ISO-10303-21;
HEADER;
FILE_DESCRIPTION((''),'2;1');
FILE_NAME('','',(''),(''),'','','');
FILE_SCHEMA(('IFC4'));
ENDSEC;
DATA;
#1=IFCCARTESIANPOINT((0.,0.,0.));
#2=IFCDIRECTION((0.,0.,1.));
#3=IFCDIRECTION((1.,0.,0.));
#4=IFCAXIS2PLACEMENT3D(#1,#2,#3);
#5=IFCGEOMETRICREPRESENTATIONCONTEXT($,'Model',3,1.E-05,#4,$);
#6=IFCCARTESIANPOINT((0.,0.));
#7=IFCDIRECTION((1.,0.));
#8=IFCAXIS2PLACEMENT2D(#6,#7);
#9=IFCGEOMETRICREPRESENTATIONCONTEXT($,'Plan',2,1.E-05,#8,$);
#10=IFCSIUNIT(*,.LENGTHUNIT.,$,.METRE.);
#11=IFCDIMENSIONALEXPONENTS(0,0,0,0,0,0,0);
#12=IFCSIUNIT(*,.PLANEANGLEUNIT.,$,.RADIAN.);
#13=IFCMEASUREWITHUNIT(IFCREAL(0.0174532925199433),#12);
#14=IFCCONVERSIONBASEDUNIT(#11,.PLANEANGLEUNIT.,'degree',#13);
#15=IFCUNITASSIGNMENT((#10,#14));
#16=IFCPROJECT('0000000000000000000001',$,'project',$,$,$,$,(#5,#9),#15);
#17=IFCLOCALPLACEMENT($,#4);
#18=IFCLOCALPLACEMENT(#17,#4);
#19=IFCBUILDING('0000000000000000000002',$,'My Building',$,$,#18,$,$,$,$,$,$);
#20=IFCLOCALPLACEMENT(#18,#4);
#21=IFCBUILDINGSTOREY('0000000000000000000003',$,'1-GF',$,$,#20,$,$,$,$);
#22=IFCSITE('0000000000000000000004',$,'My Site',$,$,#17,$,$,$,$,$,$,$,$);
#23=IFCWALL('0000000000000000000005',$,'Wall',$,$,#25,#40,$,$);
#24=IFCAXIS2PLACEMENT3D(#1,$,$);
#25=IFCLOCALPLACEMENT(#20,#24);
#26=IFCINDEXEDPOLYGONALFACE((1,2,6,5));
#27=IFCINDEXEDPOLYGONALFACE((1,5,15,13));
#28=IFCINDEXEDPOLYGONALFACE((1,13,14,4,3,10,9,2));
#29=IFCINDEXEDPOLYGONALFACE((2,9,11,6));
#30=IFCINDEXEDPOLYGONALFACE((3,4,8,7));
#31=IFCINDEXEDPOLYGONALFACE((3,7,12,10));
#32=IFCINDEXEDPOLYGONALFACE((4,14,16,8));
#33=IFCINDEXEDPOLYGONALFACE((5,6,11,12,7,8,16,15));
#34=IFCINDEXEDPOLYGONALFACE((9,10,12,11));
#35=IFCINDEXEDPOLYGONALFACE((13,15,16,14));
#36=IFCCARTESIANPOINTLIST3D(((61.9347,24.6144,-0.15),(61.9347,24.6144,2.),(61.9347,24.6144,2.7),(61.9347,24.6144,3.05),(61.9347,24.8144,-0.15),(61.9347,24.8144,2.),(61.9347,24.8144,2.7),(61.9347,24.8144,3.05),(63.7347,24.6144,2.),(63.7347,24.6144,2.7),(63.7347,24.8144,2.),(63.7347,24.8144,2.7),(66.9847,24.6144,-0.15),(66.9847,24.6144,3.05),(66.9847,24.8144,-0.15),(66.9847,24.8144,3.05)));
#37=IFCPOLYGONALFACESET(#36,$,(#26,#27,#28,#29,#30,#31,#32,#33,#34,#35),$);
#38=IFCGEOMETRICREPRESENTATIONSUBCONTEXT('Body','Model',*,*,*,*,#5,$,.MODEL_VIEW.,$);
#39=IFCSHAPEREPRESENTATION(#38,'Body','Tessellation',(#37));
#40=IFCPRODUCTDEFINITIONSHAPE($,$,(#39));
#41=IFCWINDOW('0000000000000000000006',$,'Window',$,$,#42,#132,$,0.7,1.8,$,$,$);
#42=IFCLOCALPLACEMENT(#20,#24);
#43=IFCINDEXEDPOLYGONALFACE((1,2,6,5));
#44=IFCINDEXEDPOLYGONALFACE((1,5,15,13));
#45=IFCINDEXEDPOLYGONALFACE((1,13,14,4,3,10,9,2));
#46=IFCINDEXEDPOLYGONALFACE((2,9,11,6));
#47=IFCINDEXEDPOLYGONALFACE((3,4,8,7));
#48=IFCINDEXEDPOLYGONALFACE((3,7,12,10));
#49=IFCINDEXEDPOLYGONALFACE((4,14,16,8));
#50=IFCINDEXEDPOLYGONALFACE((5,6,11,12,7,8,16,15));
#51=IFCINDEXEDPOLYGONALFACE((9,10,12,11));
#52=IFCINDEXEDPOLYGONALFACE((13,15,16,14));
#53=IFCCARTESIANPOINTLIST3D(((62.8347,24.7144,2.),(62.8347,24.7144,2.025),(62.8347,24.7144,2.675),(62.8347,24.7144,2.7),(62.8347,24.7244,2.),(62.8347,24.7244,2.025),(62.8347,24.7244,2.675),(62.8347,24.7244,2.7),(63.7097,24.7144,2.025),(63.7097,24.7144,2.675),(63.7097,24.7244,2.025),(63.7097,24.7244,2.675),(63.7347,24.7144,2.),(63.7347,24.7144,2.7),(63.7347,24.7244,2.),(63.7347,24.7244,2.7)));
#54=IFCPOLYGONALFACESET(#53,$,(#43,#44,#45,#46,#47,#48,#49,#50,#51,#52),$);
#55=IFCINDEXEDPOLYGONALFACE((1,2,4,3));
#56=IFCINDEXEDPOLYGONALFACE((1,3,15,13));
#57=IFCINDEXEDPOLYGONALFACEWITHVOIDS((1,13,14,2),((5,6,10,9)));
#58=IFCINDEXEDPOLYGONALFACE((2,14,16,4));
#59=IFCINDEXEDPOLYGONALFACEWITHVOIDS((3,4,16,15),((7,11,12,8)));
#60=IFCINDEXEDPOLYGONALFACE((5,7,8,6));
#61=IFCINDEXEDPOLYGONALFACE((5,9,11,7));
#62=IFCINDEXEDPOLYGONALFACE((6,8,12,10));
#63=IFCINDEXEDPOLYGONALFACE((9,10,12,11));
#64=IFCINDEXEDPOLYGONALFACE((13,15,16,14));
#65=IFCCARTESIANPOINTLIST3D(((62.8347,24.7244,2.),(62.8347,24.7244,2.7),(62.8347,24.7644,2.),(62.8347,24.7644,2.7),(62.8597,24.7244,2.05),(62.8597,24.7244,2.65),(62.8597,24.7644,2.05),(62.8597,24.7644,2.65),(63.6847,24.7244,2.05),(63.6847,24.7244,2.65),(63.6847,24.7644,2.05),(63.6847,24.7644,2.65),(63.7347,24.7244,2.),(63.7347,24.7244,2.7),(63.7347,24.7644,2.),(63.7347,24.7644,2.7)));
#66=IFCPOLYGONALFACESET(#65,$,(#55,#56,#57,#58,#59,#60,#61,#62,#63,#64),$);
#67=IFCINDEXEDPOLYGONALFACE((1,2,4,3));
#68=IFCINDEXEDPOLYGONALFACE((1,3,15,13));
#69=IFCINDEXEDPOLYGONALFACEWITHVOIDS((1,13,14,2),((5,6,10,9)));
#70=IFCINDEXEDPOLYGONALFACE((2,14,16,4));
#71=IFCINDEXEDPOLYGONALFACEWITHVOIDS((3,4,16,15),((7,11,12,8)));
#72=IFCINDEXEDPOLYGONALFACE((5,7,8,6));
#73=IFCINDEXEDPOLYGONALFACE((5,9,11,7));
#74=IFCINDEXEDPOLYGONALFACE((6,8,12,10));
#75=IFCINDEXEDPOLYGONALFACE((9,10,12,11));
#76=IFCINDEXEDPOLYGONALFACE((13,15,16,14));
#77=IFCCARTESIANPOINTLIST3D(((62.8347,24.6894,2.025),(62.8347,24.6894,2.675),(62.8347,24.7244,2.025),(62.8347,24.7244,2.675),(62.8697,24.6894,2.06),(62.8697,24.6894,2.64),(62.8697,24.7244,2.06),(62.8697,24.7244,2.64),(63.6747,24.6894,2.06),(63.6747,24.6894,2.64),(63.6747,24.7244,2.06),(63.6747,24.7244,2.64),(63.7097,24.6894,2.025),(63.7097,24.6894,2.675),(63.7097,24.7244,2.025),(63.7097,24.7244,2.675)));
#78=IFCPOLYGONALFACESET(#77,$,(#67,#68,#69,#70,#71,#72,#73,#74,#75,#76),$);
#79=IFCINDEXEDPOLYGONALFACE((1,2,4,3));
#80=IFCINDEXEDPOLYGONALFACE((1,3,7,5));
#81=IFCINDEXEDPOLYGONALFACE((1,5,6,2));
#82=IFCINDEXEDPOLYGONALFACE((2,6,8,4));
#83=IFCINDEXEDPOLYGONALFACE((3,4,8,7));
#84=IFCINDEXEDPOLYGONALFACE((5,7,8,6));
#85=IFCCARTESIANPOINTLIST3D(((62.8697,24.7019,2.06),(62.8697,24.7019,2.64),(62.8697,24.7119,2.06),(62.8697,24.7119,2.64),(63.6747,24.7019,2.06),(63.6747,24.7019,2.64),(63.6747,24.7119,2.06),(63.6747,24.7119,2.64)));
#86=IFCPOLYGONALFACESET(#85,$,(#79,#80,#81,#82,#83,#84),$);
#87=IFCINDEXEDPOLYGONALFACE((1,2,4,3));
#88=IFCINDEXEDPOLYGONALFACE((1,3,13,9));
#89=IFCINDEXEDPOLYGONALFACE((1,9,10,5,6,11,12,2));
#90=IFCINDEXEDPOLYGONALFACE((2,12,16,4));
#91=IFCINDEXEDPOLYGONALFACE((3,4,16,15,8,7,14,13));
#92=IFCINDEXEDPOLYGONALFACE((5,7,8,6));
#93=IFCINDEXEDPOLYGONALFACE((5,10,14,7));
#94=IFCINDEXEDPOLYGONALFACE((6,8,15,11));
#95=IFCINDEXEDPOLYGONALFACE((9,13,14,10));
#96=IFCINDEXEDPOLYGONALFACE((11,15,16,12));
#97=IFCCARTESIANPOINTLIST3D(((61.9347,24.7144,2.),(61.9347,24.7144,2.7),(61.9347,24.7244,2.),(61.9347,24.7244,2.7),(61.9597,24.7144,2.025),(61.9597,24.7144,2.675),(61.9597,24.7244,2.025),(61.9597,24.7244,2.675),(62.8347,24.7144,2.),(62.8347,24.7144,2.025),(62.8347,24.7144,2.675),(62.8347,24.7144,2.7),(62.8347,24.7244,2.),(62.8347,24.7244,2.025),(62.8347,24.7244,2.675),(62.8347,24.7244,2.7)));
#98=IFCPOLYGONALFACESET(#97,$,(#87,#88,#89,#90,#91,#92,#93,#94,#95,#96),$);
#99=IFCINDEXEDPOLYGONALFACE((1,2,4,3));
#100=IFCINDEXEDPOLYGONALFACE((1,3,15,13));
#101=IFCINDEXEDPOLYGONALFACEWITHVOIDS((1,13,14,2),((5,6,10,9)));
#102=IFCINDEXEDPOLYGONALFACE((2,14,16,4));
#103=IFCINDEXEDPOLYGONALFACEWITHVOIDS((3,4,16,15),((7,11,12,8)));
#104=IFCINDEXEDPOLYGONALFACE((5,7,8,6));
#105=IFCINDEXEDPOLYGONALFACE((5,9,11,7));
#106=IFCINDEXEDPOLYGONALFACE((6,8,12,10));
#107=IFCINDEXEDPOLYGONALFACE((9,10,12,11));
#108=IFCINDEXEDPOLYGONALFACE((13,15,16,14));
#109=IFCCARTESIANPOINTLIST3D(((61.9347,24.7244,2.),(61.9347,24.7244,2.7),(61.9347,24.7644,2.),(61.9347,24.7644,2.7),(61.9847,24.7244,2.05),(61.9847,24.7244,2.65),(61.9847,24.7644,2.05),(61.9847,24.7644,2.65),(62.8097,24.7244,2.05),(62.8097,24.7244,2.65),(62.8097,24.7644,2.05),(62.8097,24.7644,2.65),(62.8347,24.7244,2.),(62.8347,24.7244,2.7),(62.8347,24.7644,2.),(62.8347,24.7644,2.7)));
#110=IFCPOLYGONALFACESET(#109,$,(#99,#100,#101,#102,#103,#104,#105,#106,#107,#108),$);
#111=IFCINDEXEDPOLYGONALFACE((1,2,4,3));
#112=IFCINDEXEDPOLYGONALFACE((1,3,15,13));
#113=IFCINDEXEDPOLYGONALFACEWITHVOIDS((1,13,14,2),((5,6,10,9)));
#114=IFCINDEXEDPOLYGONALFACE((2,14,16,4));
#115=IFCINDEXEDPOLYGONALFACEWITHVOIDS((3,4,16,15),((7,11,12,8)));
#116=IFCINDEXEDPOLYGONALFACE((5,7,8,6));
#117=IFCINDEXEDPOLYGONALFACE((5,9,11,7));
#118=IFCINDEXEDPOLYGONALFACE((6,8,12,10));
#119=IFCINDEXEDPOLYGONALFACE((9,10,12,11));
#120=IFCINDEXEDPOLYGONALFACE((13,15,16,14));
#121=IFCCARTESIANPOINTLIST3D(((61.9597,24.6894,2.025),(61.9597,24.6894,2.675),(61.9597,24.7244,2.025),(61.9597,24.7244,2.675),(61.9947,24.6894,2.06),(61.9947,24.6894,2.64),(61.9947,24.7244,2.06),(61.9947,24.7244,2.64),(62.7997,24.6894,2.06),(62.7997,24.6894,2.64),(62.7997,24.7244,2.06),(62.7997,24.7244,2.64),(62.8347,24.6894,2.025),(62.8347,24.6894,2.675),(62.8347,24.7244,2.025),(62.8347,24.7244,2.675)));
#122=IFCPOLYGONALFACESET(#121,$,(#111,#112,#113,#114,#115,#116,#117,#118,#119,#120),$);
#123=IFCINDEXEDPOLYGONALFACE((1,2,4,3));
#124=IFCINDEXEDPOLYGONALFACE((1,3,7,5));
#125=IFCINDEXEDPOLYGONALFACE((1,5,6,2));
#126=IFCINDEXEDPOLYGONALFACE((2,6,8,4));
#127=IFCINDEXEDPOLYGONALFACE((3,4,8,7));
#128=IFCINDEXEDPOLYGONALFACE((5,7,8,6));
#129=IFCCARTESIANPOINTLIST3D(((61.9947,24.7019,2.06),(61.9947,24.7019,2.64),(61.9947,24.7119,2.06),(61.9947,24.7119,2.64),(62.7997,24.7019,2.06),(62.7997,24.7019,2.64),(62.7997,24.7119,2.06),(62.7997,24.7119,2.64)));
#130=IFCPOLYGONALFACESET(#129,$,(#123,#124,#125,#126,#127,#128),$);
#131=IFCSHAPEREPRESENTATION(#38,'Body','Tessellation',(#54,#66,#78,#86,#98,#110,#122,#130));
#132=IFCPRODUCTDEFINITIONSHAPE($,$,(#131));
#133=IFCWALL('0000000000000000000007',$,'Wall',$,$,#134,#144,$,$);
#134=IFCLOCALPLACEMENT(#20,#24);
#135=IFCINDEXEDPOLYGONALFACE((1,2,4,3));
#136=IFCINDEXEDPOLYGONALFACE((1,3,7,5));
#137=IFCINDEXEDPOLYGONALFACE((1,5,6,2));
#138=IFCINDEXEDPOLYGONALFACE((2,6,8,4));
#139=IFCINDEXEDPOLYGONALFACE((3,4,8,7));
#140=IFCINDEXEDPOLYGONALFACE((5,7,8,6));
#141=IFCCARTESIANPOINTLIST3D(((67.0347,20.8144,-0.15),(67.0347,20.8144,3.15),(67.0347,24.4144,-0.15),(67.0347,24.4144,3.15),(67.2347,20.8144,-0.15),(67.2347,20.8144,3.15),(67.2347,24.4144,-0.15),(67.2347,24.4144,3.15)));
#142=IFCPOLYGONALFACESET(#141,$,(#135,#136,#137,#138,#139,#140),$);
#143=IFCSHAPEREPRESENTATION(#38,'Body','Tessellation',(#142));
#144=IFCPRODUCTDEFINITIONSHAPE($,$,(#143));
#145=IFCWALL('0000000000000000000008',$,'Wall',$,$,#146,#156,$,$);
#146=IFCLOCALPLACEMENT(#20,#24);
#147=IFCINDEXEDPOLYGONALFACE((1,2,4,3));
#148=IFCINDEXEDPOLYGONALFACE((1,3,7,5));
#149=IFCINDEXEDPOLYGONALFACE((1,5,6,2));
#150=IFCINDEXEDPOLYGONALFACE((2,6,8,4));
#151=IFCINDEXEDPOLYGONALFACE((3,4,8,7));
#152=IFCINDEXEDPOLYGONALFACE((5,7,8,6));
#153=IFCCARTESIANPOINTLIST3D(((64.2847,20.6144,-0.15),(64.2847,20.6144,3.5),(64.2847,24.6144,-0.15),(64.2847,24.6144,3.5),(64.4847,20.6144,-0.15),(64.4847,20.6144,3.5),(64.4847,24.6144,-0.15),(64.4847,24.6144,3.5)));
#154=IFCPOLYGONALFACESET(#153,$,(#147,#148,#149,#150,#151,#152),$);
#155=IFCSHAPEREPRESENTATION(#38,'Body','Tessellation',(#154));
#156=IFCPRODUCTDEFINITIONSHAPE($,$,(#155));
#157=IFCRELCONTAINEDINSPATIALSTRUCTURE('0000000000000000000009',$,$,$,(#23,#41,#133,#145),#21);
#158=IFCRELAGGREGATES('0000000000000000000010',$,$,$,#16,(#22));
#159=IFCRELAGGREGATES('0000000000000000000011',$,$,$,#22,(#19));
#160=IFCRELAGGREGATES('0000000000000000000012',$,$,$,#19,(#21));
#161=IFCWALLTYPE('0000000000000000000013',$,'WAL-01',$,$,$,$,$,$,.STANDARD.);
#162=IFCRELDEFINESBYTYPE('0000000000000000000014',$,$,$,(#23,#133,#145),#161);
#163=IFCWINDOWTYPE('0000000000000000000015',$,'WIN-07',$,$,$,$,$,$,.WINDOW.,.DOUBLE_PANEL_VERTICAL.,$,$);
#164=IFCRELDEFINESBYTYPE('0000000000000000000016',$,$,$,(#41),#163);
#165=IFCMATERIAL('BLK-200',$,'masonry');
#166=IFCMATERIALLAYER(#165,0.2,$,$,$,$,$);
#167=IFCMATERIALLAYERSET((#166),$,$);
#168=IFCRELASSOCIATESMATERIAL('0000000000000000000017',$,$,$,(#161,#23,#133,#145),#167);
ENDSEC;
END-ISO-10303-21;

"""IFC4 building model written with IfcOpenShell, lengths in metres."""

from ifc_helpers import new_model, entity, si_unit, converted_unit, frame, origin_with_axes, origin_2d_with_axis, place, context, subcontext, project, spatial, line, indexed_curve, outline, extrude, shape, source, transform, mapped, material, layer, layer_set, layer_usage, type_object, type_shapes, element, fill, save


model = new_model("IFC4")

# Units and contexts
model_context = context("Model", 3, precision=1e-05, world=origin_with_axes())
plan_context = context("Plan", 2, precision=1e-05, world=origin_2d_with_axis())
body_context_1 = subcontext(model_context, "Body", "Model", "MODEL_VIEW")
body_context_2 = subcontext(plan_context, "Body", "Plan", "PLAN_VIEW")
ifc_project = project(units=[si_unit("LENGTHUNIT", "METRE"), converted_unit("PLANEANGLEUNIT", "degree", entity("IfcReal", 0.0174532925199433), si_unit("PLANEANGLEUNIT", "RADIAN"), dimensions=[0, 0, 0, 0, 0, 0, 0])], contexts=[model_context, plan_context])

# Site, building, storey
site_placement = place(None, origin_with_axes())
site = spatial("IfcSite", under=ifc_project, at=site_placement, Name="My Site")
building_placement = place(site_placement, origin_with_axes())
building = spatial("IfcBuilding", under=site, at=building_placement, Name="My Building")
storey_placement = place(building_placement, origin_with_axes())
storey = spatial("IfcBuildingStorey", under=building, at=storey_placement, Name="1-GF")

# Shared definitions
ifc_material_1 = material(Name="BLK-200", Category="masonry")
ifc_layer_1 = layer(ifc_material_1, 0.2)
ifc_layer_set_1 = layer_set([ifc_layer_1])
wall_type_1 = type_object("IfcWallType", Name="WAL-01", PredefinedType="STANDARD", material=ifc_layer_set_1)
shared_shape_1 = source(origin_with_axes(), body_context_1, "Body", "SweptSolid", [
    extrude(outline(indexed_curve([(0.0, 0.0), (1.8, 0.0), (1.8, 0.7), (0.0, 0.7)], segments=[line(1, 2, 3, 4, 1)])), frame((0.0, -0.1, 0.0), z_axis=(0.0, -1.0, 0.0), x_axis=(1.0, 0.0, 0.0)), (0.0, 0.0, -1.0), 0.4),
])
window_type_1 = type_object("IfcWindowType", Name="WIN-07", PartitioningType="DOUBLE_PANEL_VERTICAL", PredefinedType="WINDOW")
shared_shape_2 = source(origin_with_axes(), body_context_1, "Body", "SweptSolid", [
    extrude(outline(indexed_curve([(0.9, 0.0), (0.0, 0.0), (0.0, 0.7), (0.9, 0.7), (0.9, 0.675), (0.025, 0.675), (0.025, 0.025), (0.9, 0.025)], segments=[line(1, 2, 3, 4, 5, 6, 7, 8, 1)])), frame((0.0, 0.09, 0.0), z_axis=(0.0, -1.0, 0.0), x_axis=(1.0, 0.0, 0.0)), (0.0, 0.0, -1.0), 0.01),
    extrude(outline(indexed_curve([(0.0, 0.0), (0.9, 0.0), (0.9, 0.7), (0.0, 0.7)], segments=[line(1, 2, 3, 4, 1)]), holes=[indexed_curve([(0.05, 0.05), (0.875, 0.05), (0.875, 0.65), (0.05, 0.65)], segments=[line(1, 2, 3, 4, 1)])]), frame((0.0, 0.05, 0.0), z_axis=(0.0, -1.0, 0.0), x_axis=(1.0, 0.0, 0.0)), (0.0, 0.0, -1.0), 0.04),
    extrude(outline(indexed_curve([(0.0, 0.0), (0.875, 0.0), (0.875, 0.65), (0.0, 0.65)], segments=[line(1, 2, 3, 4, 1)]), holes=[indexed_curve([(0.035, 0.035), (0.84, 0.035), (0.84, 0.615), (0.035, 0.615)], segments=[line(1, 2, 3, 4, 1)])]), frame((0.025, 0.09, 0.025), z_axis=(0.0, -1.0, 0.0), x_axis=(1.0, 0.0, 0.0)), (0.0, 0.0, -1.0), 0.035),
    extrude(outline(indexed_curve([(0.035, 0.035), (0.84, 0.035), (0.84, 0.615), (0.035, 0.615)], segments=[line(1, 2, 3, 4, 1)])), frame((0.025, 0.1025, 0.025), z_axis=(0.0, -1.0, 0.0), x_axis=(1.0, 0.0, 0.0)), (0.0, 0.0, -1.0), 0.01),
    extrude(outline(indexed_curve([(0.0, 0.7), (0.9, 0.7), (0.9, 0.0), (0.0, 0.0), (0.0, 0.025), (0.875, 0.025), (0.875, 0.675), (0.0, 0.675)], segments=[line(1, 2, 3, 4, 5, 6, 7, 8, 1)])), frame((0.9, 0.09, 0.0), z_axis=(0.0, -1.0, 0.0), x_axis=(1.0, 0.0, 0.0)), (0.0, 0.0, -1.0), 0.01),
    extrude(outline(indexed_curve([(0.0, 0.0), (0.9, 0.0), (0.9, 0.7), (0.0, 0.7)], segments=[line(1, 2, 3, 4, 1)]), holes=[indexed_curve([(0.025, 0.05), (0.85, 0.05), (0.85, 0.65), (0.025, 0.65)], segments=[line(1, 2, 3, 4, 1)])]), frame((0.9, 0.05, 0.0), z_axis=(0.0, -1.0, 0.0), x_axis=(1.0, 0.0, 0.0)), (0.0, 0.0, -1.0), 0.04),
    extrude(outline(indexed_curve([(0.0, 0.0), (0.875, 0.0), (0.875, 0.65), (0.0, 0.65)], segments=[line(1, 2, 3, 4, 1)]), holes=[indexed_curve([(0.035, 0.035), (0.84, 0.035), (0.84, 0.615), (0.035, 0.615)], segments=[line(1, 2, 3, 4, 1)])]), frame((0.9, 0.09, 0.025), z_axis=(0.0, -1.0, 0.0), x_axis=(1.0, 0.0, 0.0)), (0.0, 0.0, -1.0), 0.035),
    extrude(outline(indexed_curve([(0.035, 0.035), (0.84, 0.035), (0.84, 0.615), (0.035, 0.615)], segments=[line(1, 2, 3, 4, 1)])), frame((0.9, 0.1025, 0.025), z_axis=(0.0, -1.0, 0.0), x_axis=(1.0, 0.0, 0.0)), (0.0, 0.0, -1.0), 0.01),
])
shared_shape_3 = source(origin_with_axes(), body_context_2, "Body", "Curve2D", [
    entity("IfcIndexedPolyCurve", entity("IfcCartesianPointList2D", [[0.05, 0.05], [0.875, 0.05]])),
    entity("IfcIndexedPolyCurve", entity("IfcCartesianPointList2D", [[0.0, 0.1], [0.025, 0.1], [0.025, 0.09], [0.05, 0.09], [0.05, 0.05], [0.0, 0.05]]), [entity("IfcLineIndex", [1, 2, 3, 4, 5, 6, 1])]),
    entity("IfcIndexedPolyCurve", entity("IfcCartesianPointList2D", [[0.9, 0.1], [0.9, 0.1], [0.9, 0.09], [0.875, 0.09], [0.875, 0.05], [0.9, 0.05]])),
    entity("IfcIndexedPolyCurve", entity("IfcCartesianPointList2D", [[0.025, 0.09], [0.06, 0.09], [0.06, 0.125], [0.025, 0.125]]), [entity("IfcLineIndex", [1, 2, 3, 4, 1])]),
    entity("IfcIndexedPolyCurve", entity("IfcCartesianPointList2D", [[0.9, 0.09], [0.865, 0.09], [0.865, 0.125], [0.9, 0.125]]), [entity("IfcLineIndex", [1, 2, 3, 4, 1])]),
    entity("IfcIndexedPolyCurve", entity("IfcCartesianPointList2D", [[0.06, 0.09], [0.865, 0.09]])),
    entity("IfcIndexedPolyCurve", entity("IfcCartesianPointList2D", [[0.06, 0.125], [0.865, 0.125]])),
    entity("IfcIndexedPolyCurve", entity("IfcCartesianPointList2D", [[0.06, 0.1075], [0.865, 0.1075]])),
    entity("IfcIndexedPolyCurve", entity("IfcCartesianPointList2D", [[0.925, 0.05], [1.75, 0.05]])),
    entity("IfcIndexedPolyCurve", entity("IfcCartesianPointList2D", [[0.9, 0.1], [0.9, 0.1], [0.9, 0.09], [0.925, 0.09], [0.925, 0.05], [0.9, 0.05]])),
    entity("IfcIndexedPolyCurve", entity("IfcCartesianPointList2D", [[1.8, 0.1], [1.775, 0.1], [1.775, 0.09], [1.75, 0.09], [1.75, 0.05], [1.8, 0.05]]), [entity("IfcLineIndex", [1, 2, 3, 4, 5, 6, 1])]),
    entity("IfcIndexedPolyCurve", entity("IfcCartesianPointList2D", [[0.9, 0.09], [0.935, 0.09], [0.935, 0.125], [0.9, 0.125]]), [entity("IfcLineIndex", [1, 2, 3, 4, 1])]),
    entity("IfcIndexedPolyCurve", entity("IfcCartesianPointList2D", [[1.775, 0.09], [1.74, 0.09], [1.74, 0.125], [1.775, 0.125]]), [entity("IfcLineIndex", [1, 2, 3, 4, 1])]),
    entity("IfcIndexedPolyCurve", entity("IfcCartesianPointList2D", [[0.935, 0.09], [1.74, 0.09]])),
    entity("IfcIndexedPolyCurve", entity("IfcCartesianPointList2D", [[0.935, 0.125], [1.74, 0.125]])),
    entity("IfcIndexedPolyCurve", entity("IfcCartesianPointList2D", [[0.935, 0.1075], [1.74, 0.1075]])),
])
type_shapes(window_type_1, [shared_shape_2, shared_shape_3])

# Wall, opening, window
ifc_layer_usage_1 = layer_usage(ifc_layer_set_1, "AXIS2", "POSITIVE", 0.0)
wall_1_placement = place(storey_placement, frame((66.9847, 24.8144, -0.15), z_axis=(0.0, 0.0, 1.0), x_axis=(-1.0, 0.0, 0.0)))
wall_1 = element("IfcWall", 1, at=wall_1_placement, inside=storey, type_object=wall_type_1, material=ifc_layer_usage_1, Name="Wall", context=body_context_1, shape_type="SweptSolid", body=[
    extrude(outline(indexed_curve([(0.0, 0.0), (0.0, 0.2), (5.05, 0.2), (5.05, 0.0), (0.0, 0.0)], self_intersect=False)), origin_with_axes(), (0.0, 0.0, 1.0), 3.2),
])
opening_1_placement = place(wall_1_placement, frame((3.25, 0.0, 2.15), z_axis=(0.0, 0.0, 1.0), x_axis=(1.0, 0.0, 0.0)))
opening_1 = element("IfcOpeningElement", 2, at=opening_1_placement, cuts=wall_1, PredefinedType="OPENING", context=body_context_1, shape_type="MappedRepresentation", body=[
    mapped(shared_shape_1, transform((0.0, 0.0, 0.0), x_axis=(1.0, 0.0, 0.0), y_axis=(0.0, 1.0, 0.0), z_axis=(0.0, 0.0, 1.0), scale=1.0)),
])
window_1_placement = place(opening_1_placement, frame((0.0, 0.0, 0.0), z_axis=(0.0, 0.0, 1.0), x_axis=(1.0, 0.0, 0.0)))
window_1 = element("IfcWindow", 3, at=window_1_placement, inside=storey, type_object=window_type_1, Name="Window", OverallHeight=0.7, OverallWidth=1.8, shapes=[
    shape(body_context_1, "Body", "MappedRepresentation", [mapped(shared_shape_2, transform((0.0, 0.0, 0.0), x_axis=(1.0, 0.0, 0.0), y_axis=(0.0, 1.0, 0.0), z_axis=(0.0, 0.0, 1.0), scale=1.0))]),
    shape(body_context_2, "Body", "MappedRepresentation", [mapped(shared_shape_3, transform((0.0, 0.0, 0.0), x_axis=(1.0, 0.0, 0.0), y_axis=(0.0, 1.0, 0.0), z_axis=(0.0, 0.0, 1.0), scale=1.0))]),
])
fill(opening_1, window_1)

# Walls
ifc_layer_usage_2 = layer_usage(ifc_layer_set_1, "AXIS2", "POSITIVE", 0.0)
wall_2_placement = place(storey_placement, frame((67.2347, 20.8144, -0.15), z_axis=(0.0, 0.0, 1.0), x_axis=(0.000001, 1.0, 0.0)))
element("IfcWall", 4, at=wall_2_placement, inside=storey, type_object=wall_type_1, material=ifc_layer_usage_2, Name="Wall", context=body_context_1, shape_type="SweptSolid", body=[
    extrude(outline(indexed_curve([(0.0, 0.0), (0.0, 0.2), (3.6, 0.2), (3.6, 0.0), (0.0, 0.0)], self_intersect=False)), origin_with_axes(), (0.0, 0.0, 1.0), 3.3),
])
ifc_layer_usage_3 = layer_usage(ifc_layer_set_1, "AXIS2", "POSITIVE", 0.0)
wall_3_placement = place(storey_placement, frame((64.4847, 20.6144, -0.15), z_axis=(0.0, 0.0, 1.0), x_axis=(0.000001, 1.0, 0.0)))
element("IfcWall", 5, at=wall_3_placement, inside=storey, type_object=wall_type_1, material=ifc_layer_usage_3, Name="Wall", context=body_context_1, shape_type="SweptSolid", body=[
    extrude(outline(indexed_curve([(0.0, 0.0), (0.0, 0.2), (4.0, 0.2), (4.0, 0.0), (0.0, 0.0)], self_intersect=False)), origin_with_axes(), (0.0, 0.0, 1.0), 3.65),
])

save(model, "model.ifc")
